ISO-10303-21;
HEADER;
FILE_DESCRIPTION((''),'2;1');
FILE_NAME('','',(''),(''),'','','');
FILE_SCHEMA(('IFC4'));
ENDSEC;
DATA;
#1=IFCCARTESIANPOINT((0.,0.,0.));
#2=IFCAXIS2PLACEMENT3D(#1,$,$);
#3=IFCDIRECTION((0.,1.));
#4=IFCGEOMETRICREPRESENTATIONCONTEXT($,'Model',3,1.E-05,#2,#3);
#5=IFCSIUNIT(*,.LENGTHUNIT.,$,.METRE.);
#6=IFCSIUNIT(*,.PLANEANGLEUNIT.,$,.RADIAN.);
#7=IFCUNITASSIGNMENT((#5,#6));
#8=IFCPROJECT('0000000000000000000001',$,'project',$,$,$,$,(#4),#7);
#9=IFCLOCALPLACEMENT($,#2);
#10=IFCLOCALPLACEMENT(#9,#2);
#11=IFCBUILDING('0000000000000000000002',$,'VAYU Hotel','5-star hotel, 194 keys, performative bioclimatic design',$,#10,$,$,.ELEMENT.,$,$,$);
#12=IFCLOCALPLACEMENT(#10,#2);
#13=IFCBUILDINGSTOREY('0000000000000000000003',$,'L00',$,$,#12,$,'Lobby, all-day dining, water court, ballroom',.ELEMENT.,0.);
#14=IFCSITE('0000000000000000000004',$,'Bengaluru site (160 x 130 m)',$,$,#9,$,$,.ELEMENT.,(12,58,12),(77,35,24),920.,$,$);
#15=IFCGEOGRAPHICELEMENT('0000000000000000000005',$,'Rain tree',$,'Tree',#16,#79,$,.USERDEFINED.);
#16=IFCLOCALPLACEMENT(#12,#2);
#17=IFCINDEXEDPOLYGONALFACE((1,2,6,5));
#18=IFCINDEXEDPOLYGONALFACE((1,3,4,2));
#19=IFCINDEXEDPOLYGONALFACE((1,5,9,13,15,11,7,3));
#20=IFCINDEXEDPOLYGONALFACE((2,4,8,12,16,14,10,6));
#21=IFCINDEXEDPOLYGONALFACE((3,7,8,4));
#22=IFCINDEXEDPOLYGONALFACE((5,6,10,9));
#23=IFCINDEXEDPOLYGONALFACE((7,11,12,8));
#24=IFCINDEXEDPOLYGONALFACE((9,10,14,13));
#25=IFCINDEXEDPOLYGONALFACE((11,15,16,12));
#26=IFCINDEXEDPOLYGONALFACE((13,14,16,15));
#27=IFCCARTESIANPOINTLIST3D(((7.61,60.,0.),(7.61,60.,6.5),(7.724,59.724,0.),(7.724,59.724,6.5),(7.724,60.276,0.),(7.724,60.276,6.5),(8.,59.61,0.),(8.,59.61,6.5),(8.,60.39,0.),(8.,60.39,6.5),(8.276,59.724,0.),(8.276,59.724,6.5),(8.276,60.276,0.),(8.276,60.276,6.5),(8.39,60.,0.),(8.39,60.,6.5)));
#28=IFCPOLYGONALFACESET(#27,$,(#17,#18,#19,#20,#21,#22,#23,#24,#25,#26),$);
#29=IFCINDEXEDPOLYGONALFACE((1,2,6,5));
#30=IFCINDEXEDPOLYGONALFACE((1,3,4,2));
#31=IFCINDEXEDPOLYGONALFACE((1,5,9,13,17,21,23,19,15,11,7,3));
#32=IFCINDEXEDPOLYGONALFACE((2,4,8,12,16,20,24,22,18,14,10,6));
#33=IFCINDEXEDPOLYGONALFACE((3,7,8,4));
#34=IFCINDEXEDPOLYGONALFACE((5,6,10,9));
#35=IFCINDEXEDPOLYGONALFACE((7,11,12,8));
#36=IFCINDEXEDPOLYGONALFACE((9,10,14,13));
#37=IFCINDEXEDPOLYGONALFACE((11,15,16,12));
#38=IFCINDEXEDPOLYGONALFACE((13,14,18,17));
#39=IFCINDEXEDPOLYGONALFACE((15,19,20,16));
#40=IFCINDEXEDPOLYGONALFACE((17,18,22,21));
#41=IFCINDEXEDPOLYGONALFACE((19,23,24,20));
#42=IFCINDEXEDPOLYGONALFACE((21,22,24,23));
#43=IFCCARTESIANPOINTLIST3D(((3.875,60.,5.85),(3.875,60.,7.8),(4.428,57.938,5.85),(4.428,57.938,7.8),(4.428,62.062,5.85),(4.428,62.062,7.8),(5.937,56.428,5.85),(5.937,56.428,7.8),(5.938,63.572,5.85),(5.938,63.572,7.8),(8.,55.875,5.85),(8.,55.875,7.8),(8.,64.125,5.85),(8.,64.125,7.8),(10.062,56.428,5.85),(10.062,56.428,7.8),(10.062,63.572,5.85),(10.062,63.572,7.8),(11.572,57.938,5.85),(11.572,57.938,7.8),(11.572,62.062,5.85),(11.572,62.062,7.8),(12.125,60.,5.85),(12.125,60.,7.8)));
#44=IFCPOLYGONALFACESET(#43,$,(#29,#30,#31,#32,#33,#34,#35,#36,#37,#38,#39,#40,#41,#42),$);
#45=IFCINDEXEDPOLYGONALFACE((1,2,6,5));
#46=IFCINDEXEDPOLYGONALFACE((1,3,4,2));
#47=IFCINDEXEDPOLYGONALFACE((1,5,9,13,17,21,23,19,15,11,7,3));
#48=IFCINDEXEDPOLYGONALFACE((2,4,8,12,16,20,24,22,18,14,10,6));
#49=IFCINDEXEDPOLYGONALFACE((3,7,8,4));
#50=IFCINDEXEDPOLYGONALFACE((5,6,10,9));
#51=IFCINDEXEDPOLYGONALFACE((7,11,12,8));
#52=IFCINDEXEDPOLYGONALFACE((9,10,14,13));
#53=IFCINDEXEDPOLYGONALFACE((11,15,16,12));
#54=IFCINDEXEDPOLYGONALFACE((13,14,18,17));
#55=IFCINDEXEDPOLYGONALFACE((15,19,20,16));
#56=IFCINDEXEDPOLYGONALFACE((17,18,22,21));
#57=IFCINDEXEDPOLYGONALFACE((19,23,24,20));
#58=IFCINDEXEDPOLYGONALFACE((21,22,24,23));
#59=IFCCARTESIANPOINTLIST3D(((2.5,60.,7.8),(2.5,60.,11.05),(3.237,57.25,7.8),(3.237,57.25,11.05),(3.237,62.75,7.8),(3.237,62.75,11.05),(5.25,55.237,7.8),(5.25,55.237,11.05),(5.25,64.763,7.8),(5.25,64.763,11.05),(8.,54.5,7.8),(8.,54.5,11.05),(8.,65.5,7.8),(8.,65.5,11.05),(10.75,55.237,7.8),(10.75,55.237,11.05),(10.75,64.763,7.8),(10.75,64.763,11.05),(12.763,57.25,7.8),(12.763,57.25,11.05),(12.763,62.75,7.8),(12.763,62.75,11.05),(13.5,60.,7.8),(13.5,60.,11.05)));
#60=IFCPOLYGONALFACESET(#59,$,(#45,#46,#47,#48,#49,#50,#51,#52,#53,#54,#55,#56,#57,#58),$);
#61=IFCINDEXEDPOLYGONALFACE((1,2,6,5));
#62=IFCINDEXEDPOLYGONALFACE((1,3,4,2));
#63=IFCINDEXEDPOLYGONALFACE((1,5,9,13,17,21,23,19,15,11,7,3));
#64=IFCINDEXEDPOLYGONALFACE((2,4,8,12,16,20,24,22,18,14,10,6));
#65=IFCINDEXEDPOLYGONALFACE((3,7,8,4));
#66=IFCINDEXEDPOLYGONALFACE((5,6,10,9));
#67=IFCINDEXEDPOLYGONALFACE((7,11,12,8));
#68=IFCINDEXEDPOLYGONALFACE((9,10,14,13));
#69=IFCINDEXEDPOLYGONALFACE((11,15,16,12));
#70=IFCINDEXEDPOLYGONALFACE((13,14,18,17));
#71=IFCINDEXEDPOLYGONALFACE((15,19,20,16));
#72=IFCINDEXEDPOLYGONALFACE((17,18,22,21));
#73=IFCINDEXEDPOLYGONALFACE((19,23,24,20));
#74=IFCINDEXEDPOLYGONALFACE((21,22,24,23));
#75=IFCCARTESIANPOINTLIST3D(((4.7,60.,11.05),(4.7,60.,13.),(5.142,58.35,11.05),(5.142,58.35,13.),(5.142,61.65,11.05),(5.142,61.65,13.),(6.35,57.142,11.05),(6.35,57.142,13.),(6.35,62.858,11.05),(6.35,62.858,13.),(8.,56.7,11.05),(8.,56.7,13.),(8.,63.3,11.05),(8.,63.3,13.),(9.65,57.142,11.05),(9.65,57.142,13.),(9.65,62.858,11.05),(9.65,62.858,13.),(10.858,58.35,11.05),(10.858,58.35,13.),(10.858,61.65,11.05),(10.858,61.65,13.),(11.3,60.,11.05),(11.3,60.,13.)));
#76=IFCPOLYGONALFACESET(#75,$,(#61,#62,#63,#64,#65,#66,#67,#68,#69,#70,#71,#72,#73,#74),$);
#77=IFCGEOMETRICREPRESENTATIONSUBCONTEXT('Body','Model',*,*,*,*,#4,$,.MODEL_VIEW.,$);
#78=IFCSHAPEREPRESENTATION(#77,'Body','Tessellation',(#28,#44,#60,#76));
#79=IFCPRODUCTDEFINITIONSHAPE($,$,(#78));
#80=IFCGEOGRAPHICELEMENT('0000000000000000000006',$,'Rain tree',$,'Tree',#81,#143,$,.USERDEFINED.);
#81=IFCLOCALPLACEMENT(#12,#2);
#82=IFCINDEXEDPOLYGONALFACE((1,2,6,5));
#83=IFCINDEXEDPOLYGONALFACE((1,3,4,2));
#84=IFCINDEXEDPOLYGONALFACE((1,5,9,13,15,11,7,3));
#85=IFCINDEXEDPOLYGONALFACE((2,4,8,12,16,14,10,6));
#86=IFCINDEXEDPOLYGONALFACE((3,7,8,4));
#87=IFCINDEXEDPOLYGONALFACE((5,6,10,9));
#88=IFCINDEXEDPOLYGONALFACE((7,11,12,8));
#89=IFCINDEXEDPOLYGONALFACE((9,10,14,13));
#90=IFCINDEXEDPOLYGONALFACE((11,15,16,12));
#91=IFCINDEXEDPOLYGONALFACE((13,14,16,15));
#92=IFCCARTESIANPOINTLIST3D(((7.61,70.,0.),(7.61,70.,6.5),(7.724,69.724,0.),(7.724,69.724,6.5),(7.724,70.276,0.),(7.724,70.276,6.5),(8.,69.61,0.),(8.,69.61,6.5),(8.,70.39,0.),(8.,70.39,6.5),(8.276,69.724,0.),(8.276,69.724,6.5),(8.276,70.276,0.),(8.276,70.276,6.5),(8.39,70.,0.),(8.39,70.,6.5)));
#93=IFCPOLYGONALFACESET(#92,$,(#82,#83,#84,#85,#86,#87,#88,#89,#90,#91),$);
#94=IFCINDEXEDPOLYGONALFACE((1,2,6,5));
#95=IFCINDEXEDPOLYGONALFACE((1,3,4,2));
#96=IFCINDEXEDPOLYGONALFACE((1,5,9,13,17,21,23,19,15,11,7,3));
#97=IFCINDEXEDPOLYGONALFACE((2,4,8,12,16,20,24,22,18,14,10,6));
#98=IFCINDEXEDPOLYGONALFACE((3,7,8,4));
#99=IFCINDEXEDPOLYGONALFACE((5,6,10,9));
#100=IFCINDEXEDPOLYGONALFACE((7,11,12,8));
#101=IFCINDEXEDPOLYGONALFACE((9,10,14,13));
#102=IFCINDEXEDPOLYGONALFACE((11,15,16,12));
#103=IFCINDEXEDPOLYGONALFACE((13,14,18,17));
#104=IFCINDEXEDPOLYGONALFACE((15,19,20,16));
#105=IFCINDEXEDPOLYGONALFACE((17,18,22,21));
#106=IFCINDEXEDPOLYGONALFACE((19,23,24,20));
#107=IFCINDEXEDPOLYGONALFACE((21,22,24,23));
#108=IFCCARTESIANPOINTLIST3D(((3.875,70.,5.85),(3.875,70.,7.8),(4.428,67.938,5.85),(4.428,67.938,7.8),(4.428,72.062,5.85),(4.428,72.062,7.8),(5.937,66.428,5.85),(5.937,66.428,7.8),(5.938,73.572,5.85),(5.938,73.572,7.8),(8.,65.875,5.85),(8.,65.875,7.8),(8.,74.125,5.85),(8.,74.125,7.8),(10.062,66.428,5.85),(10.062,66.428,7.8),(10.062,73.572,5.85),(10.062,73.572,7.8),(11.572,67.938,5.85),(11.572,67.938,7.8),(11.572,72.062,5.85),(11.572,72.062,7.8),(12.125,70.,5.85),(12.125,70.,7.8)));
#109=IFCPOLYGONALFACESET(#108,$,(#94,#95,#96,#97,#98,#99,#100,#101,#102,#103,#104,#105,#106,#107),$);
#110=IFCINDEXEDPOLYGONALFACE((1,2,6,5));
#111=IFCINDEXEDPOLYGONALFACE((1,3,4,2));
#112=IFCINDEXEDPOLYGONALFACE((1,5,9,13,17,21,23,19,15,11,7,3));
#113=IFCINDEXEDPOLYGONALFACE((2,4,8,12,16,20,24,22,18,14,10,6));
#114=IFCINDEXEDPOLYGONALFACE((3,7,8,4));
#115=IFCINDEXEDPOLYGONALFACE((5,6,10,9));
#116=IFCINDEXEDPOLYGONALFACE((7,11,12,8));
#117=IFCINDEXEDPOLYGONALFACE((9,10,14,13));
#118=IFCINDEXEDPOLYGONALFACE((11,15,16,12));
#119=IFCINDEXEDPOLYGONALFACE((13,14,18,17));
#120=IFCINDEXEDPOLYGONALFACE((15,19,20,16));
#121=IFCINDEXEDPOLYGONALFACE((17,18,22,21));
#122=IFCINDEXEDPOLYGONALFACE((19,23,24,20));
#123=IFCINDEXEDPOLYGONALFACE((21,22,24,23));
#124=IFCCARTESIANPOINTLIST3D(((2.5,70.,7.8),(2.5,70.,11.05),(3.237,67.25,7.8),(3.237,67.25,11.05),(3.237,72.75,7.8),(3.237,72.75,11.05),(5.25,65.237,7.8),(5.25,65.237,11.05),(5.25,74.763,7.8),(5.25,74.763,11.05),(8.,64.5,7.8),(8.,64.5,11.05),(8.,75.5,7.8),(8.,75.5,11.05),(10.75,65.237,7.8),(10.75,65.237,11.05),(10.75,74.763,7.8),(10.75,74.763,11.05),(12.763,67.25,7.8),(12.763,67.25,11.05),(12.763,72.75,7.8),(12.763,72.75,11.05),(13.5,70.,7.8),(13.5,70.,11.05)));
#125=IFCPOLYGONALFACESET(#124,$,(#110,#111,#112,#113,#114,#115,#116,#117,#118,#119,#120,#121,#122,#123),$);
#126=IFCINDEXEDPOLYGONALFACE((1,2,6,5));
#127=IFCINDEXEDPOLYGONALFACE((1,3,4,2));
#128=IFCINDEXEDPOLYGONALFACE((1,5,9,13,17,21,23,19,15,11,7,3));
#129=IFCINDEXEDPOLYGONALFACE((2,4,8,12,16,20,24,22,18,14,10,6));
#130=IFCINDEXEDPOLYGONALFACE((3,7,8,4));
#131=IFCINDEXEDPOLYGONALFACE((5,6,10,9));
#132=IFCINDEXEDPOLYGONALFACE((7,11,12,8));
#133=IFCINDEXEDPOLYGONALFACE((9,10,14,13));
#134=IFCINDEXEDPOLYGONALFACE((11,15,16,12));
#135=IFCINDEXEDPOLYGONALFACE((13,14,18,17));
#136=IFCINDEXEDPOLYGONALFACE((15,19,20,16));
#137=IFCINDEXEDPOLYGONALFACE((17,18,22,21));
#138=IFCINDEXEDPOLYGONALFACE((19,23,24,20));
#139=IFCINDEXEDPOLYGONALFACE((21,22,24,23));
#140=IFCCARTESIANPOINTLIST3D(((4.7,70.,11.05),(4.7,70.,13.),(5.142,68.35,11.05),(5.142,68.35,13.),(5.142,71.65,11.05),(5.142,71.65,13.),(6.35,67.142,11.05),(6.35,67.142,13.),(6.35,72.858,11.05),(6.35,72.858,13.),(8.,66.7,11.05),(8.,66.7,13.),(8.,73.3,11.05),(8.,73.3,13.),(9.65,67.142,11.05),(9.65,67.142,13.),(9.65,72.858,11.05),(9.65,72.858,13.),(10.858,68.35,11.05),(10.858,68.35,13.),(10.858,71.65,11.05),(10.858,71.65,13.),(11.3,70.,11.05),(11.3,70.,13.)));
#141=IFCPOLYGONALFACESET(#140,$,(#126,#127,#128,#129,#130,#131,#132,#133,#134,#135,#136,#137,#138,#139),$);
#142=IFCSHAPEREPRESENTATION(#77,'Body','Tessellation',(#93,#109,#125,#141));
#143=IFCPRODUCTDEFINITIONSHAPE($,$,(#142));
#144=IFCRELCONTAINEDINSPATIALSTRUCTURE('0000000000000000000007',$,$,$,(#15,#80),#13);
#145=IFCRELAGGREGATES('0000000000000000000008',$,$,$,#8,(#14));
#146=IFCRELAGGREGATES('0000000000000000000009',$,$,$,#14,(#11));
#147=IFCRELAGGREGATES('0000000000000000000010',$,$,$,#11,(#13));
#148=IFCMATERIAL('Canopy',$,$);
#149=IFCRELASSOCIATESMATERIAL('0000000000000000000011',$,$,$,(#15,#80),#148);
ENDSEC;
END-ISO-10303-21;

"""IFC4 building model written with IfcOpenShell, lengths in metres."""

from ifc_helpers import new_model, si_unit, direction, frame, origin, place, context, subcontext, project, spatial, polyline, outline, extrude, material, element, save


model = new_model("IFC4")

# Units and contexts
model_context = context("Model", 3, precision=1e-05, world=origin(), true_north=direction((0.0, 1.0)))
body_context = subcontext(model_context, "Body", "Model", "MODEL_VIEW")
ifc_project = project(units=[si_unit("LENGTHUNIT", "METRE"), si_unit("PLANEANGLEUNIT", "RADIAN")], contexts=[model_context])

# Site, building, storey
site_placement = place(None, origin())
site = spatial("IfcSite", under=ifc_project, at=site_placement, Name="Bengaluru site (160 x 130 m)", CompositionType="ELEMENT", RefLatitude=(12, 58, 12), RefLongitude=(77, 35, 24), RefElevation=920.0)
building_placement = place(site_placement, origin())
building = spatial("IfcBuilding", under=site, at=building_placement, Name="VAYU Hotel", Description="5-star hotel, 194 keys, performative bioclimatic design", CompositionType="ELEMENT")
storey_placement = place(building_placement, origin())
storey = spatial("IfcBuildingStorey", under=building, at=storey_placement, Name="L00", LongName="Lobby, all-day dining, water court, ballroom", CompositionType="ELEMENT", Elevation=0.0)

# Geographic elements
ifc_material_1 = material(Name="Canopy")
geographic_element_1_placement = place(storey_placement, origin())
element("IfcGeographicElement", 1, at=geographic_element_1_placement, inside=storey, material=ifc_material_1, Name="Rain tree", ObjectType="Tree", PredefinedType="USERDEFINED", context=body_context, shape_type="SweptSolid", body=[
    extrude(outline(polyline([(8.39, 60.0), (8.276, 60.276), (8.0, 60.39), (7.724, 60.276), (7.61, 60.0), (7.724, 59.724), (8.0, 59.61), (8.276, 59.724), (8.39, 60.0)])), origin(), (0.0, 0.0, 1.0), 6.5),
    extrude(outline(polyline([(12.125, 60.0), (11.572, 62.062), (10.062, 63.572), (8.0, 64.125), (5.938, 63.572), (4.428, 62.062), (3.875, 60.0), (4.428, 57.938), (5.937, 56.428), (8.0, 55.875), (10.062, 56.428), (11.572, 57.938), (12.125, 60.0)])), frame((0.0, 0.0, 5.85)), (0.0, 0.0, 1.0), 1.95),
    extrude(outline(polyline([(13.5, 60.0), (12.763, 62.75), (10.75, 64.763), (8.0, 65.5), (5.25, 64.763), (3.237, 62.75), (2.5, 60.0), (3.237, 57.25), (5.25, 55.237), (8.0, 54.5), (10.75, 55.237), (12.763, 57.25), (13.5, 60.0)])), frame((0.0, 0.0, 7.8)), (0.0, 0.0, 1.0), 3.25),
    extrude(outline(polyline([(11.3, 60.0), (10.858, 61.65), (9.65, 62.858), (8.0, 63.3), (6.35, 62.858), (5.142, 61.65), (4.7, 60.0), (5.142, 58.35), (6.35, 57.142), (8.0, 56.7), (9.65, 57.142), (10.858, 58.35), (11.3, 60.0)])), frame((0.0, 0.0, 11.05)), (0.0, 0.0, 1.0), 1.95),
])
geographic_element_2_placement = place(storey_placement, origin())
element("IfcGeographicElement", 2, at=geographic_element_2_placement, inside=storey, material=ifc_material_1, Name="Rain tree", ObjectType="Tree", PredefinedType="USERDEFINED", context=body_context, shape_type="SweptSolid", body=[
    extrude(outline(polyline([(8.39, 70.0), (8.276, 70.276), (8.0, 70.39), (7.724, 70.276), (7.61, 70.0), (7.724, 69.724), (8.0, 69.61), (8.276, 69.724), (8.39, 70.0)])), origin(), (0.0, 0.0, 1.0), 6.5),
    extrude(outline(polyline([(12.125, 70.0), (11.572, 72.062), (10.062, 73.572), (8.0, 74.125), (5.938, 73.572), (4.428, 72.062), (3.875, 70.0), (4.428, 67.938), (5.937, 66.428), (8.0, 65.875), (10.062, 66.428), (11.572, 67.938), (12.125, 70.0)])), frame((0.0, 0.0, 5.85)), (0.0, 0.0, 1.0), 1.95),
    extrude(outline(polyline([(13.5, 70.0), (12.763, 72.75), (10.75, 74.763), (8.0, 75.5), (5.25, 74.763), (3.237, 72.75), (2.5, 70.0), (3.237, 67.25), (5.25, 65.237), (8.0, 64.5), (10.75, 65.237), (12.763, 67.25), (13.5, 70.0)])), frame((0.0, 0.0, 7.8)), (0.0, 0.0, 1.0), 3.25),
    extrude(outline(polyline([(11.3, 70.0), (10.858, 71.65), (9.65, 72.858), (8.0, 73.3), (6.35, 72.858), (5.142, 71.65), (4.7, 70.0), (5.142, 68.35), (6.35, 67.142), (8.0, 66.7), (9.65, 67.142), (10.858, 68.35), (11.3, 70.0)])), frame((0.0, 0.0, 11.05)), (0.0, 0.0, 1.0), 1.95),
])

save(model, "model.ifc")
